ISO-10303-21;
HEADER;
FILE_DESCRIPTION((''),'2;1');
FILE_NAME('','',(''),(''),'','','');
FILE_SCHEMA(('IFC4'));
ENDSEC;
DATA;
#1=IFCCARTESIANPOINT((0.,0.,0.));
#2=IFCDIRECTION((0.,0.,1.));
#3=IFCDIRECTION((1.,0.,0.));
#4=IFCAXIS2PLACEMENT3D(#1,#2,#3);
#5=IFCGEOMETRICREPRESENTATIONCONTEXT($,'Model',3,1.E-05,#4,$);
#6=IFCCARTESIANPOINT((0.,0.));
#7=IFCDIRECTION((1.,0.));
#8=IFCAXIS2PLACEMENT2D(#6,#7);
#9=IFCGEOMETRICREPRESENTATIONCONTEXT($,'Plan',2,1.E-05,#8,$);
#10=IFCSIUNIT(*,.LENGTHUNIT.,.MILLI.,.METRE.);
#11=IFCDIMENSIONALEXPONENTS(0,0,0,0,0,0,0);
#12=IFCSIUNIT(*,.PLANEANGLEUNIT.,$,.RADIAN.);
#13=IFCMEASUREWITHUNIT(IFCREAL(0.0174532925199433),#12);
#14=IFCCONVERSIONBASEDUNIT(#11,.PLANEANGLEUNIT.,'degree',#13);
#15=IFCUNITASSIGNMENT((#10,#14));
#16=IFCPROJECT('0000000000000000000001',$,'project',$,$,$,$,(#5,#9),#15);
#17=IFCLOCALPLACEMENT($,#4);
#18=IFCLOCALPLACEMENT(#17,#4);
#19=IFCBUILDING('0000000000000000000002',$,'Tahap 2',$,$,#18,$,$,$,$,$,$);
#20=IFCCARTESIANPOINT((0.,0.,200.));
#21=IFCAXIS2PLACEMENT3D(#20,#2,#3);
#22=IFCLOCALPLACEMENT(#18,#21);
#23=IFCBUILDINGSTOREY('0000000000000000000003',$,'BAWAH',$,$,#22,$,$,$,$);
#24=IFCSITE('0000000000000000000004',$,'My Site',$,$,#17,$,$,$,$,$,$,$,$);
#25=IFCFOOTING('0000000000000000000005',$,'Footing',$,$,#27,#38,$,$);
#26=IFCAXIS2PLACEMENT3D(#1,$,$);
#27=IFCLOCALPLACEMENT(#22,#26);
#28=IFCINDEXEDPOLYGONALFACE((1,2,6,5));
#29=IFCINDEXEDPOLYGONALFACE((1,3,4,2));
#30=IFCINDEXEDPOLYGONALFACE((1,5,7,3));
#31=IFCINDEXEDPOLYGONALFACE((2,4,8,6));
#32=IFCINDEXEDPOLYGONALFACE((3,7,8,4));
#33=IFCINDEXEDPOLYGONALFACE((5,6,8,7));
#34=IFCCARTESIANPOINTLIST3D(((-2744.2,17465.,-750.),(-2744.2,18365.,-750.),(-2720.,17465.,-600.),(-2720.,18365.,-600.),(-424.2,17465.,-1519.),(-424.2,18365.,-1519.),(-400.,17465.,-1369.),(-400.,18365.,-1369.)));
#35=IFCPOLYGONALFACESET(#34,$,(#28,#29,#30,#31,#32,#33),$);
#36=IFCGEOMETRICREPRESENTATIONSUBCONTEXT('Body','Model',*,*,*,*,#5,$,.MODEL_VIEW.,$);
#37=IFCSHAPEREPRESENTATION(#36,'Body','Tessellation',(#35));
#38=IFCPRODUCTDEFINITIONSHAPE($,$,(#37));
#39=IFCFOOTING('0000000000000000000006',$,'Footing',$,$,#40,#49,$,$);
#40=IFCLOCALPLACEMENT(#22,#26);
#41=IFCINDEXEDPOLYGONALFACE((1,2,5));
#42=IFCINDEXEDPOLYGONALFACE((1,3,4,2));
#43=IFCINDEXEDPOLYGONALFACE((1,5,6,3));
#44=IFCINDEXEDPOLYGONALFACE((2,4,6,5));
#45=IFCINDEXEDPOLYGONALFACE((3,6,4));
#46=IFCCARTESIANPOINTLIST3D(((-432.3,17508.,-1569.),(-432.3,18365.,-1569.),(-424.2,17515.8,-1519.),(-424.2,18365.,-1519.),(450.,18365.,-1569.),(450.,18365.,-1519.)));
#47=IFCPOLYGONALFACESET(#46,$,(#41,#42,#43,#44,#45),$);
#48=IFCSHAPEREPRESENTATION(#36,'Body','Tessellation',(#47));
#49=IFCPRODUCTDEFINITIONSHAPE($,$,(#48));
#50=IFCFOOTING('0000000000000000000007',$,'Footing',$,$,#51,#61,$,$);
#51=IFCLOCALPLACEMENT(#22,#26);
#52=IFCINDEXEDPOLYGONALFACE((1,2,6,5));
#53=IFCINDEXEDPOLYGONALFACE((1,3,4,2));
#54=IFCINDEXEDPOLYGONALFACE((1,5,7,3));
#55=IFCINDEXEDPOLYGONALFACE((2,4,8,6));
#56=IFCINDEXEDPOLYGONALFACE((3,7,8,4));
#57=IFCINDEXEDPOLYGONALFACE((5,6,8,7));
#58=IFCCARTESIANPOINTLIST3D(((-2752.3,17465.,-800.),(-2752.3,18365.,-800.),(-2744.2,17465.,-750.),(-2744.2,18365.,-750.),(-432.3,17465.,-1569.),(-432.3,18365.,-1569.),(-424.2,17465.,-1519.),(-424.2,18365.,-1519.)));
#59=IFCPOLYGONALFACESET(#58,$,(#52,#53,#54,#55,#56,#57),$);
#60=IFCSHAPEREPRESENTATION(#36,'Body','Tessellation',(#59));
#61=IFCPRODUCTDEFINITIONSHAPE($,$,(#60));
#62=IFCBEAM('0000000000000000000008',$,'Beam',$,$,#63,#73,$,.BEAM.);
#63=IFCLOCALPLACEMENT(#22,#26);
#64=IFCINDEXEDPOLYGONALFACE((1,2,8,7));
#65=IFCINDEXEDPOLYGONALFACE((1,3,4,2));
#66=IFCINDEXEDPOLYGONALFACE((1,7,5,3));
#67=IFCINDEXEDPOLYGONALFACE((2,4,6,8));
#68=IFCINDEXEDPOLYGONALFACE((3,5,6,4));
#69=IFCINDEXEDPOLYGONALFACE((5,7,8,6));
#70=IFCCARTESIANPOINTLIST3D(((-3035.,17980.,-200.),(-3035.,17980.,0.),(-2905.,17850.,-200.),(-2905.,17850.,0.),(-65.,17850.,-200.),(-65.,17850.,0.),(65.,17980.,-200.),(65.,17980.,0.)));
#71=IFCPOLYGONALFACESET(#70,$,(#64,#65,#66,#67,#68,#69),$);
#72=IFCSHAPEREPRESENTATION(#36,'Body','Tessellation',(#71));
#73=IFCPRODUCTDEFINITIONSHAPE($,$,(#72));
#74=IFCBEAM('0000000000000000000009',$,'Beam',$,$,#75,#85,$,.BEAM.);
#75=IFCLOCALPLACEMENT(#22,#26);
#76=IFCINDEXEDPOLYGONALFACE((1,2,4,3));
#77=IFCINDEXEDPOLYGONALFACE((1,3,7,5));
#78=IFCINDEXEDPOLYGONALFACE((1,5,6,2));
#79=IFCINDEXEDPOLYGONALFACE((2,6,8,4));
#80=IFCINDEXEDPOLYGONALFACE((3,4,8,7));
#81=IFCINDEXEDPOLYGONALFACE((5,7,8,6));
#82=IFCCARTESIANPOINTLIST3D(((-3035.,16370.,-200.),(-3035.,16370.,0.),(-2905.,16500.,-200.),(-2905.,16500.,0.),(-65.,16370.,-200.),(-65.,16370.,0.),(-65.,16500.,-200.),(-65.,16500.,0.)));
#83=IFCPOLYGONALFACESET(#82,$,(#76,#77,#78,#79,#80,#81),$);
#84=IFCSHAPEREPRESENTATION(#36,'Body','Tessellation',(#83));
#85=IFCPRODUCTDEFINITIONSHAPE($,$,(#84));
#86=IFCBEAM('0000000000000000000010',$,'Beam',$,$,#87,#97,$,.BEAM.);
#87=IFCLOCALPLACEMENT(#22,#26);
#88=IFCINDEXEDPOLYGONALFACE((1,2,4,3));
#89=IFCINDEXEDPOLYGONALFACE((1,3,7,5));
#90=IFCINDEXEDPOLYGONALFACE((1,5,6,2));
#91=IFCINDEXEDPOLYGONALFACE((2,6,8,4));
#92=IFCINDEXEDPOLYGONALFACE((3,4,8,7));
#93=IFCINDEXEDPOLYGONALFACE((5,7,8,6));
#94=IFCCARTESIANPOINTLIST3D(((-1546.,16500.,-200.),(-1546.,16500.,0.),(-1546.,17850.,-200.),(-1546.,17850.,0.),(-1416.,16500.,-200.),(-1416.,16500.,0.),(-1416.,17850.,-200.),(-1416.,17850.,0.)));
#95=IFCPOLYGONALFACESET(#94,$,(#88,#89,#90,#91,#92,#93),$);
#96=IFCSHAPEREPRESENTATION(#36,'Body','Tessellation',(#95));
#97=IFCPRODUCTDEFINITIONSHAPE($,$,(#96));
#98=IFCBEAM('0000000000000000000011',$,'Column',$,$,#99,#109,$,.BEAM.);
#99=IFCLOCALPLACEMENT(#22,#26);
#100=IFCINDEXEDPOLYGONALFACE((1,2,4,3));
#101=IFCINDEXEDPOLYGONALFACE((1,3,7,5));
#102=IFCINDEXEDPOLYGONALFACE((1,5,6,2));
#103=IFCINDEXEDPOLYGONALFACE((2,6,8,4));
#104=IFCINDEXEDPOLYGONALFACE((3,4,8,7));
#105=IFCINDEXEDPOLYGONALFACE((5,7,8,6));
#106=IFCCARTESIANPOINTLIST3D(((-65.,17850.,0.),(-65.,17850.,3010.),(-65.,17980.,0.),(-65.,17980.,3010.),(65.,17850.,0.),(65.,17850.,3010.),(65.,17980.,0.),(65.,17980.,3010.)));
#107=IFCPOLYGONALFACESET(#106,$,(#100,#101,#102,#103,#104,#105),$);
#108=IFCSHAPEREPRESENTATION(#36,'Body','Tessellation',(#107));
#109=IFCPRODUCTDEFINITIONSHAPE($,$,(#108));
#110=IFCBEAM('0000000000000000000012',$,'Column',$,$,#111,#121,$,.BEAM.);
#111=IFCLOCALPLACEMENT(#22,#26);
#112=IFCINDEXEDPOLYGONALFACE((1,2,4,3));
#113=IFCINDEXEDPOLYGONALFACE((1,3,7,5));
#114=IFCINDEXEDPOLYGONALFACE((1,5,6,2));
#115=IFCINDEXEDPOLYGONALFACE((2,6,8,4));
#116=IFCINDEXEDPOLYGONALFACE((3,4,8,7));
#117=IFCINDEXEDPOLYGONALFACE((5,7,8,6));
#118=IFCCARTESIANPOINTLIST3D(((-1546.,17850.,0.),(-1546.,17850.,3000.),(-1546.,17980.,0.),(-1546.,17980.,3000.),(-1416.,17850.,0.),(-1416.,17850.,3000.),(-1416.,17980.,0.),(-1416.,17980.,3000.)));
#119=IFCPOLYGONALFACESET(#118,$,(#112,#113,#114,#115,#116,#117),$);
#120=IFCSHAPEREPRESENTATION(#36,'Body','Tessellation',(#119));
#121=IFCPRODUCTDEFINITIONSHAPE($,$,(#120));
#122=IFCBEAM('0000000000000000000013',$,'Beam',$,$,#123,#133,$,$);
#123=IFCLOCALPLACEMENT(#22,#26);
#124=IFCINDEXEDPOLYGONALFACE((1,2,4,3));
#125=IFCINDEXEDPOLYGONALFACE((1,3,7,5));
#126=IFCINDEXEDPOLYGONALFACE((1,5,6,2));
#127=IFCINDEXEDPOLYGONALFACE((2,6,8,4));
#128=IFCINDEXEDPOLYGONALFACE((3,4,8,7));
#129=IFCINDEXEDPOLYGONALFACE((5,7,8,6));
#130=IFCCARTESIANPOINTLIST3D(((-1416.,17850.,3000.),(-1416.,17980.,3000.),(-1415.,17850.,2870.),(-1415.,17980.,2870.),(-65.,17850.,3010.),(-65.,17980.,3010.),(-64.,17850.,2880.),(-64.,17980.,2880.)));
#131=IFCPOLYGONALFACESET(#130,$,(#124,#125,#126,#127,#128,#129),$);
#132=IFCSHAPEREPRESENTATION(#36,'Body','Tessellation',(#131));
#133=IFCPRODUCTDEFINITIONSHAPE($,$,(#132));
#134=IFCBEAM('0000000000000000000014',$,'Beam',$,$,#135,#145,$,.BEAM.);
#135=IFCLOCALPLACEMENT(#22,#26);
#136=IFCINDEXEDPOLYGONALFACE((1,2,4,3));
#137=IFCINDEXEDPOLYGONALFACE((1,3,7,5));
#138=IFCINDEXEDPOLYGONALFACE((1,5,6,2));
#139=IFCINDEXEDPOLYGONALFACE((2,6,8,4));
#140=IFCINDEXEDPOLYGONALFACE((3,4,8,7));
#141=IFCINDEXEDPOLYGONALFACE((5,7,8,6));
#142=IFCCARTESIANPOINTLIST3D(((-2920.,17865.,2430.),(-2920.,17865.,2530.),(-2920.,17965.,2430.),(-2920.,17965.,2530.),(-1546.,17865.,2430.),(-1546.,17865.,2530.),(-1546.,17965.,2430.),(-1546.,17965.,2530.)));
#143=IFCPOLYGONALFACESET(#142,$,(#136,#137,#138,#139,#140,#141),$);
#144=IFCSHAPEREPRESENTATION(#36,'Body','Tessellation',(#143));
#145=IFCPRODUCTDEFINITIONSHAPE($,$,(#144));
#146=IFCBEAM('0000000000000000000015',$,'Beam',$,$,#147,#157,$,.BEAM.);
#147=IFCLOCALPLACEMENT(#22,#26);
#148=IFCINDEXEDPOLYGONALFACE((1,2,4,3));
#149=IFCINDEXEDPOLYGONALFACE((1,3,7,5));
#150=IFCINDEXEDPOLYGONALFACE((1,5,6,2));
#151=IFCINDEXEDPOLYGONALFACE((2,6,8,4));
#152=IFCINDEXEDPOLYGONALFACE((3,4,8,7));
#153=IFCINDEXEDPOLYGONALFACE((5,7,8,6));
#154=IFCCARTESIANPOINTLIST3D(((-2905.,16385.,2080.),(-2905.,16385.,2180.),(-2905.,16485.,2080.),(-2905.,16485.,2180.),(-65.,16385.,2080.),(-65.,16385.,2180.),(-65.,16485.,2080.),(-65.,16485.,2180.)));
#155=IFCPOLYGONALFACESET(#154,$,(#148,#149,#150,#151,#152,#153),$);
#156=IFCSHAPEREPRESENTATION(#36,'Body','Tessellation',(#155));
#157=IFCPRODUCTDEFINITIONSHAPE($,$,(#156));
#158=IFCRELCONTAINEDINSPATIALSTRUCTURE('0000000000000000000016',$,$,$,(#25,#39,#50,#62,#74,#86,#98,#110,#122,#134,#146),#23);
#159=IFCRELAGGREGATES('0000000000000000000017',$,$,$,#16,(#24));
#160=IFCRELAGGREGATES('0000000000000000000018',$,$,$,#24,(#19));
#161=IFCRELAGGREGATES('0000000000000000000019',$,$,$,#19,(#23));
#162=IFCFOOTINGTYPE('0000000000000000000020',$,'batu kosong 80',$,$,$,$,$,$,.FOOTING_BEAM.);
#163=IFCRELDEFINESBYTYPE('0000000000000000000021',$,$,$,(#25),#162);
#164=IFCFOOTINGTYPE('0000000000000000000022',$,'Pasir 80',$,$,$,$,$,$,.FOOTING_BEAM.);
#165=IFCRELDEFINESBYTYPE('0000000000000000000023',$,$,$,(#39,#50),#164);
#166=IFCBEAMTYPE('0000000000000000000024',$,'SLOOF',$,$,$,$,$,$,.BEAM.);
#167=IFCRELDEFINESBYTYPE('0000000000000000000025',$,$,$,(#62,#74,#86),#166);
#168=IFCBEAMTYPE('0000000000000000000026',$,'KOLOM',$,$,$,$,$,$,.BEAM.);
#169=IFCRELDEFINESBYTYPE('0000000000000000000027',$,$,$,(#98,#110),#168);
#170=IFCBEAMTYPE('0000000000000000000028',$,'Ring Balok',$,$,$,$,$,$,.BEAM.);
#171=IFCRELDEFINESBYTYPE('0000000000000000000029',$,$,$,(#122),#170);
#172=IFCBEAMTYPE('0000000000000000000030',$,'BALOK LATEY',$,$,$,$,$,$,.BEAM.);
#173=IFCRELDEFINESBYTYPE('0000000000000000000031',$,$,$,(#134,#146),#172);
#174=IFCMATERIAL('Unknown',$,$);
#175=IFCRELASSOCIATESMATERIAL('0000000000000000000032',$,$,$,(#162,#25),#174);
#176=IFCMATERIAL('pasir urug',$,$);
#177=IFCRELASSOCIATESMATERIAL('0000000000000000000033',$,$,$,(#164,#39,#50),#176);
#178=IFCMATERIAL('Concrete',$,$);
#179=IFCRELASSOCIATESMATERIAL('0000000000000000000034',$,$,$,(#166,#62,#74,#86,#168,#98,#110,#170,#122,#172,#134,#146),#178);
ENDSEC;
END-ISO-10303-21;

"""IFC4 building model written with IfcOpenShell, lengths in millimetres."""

from ifc_helpers import new_model, entity, si_unit, converted_unit, frame, origin_with_axes, origin_2d_with_axis, place, context, subcontext, project, spatial, indexed_curve, rectangle, outline, extrude, clip, halfspace, material, material_profile, profile_set, profile_usage, type_object, element, save


model = new_model("IFC4")

# Units and contexts
model_context = context("Model", 3, precision=1e-05, world=origin_with_axes())
plan_context = context("Plan", 2, precision=1e-05, world=origin_2d_with_axis())
body_context_1 = subcontext(model_context, "Body", "Model", "MODEL_VIEW")
ifc_project = project(units=[si_unit("LENGTHUNIT", "METRE", prefix="MILLI"), converted_unit("PLANEANGLEUNIT", "degree", entity("IfcReal", 0.0174532925199433), si_unit("PLANEANGLEUNIT", "RADIAN"), dimensions=[0, 0, 0, 0, 0, 0, 0])], contexts=[model_context, plan_context])

# Site, building, storey
site_placement = place(None, origin_with_axes())
site = spatial("IfcSite", under=ifc_project, at=site_placement, Name="My Site")
building_placement = place(site_placement, origin_with_axes())
building = spatial("IfcBuilding", under=site, at=building_placement, Name="Tahap 2")
storey_placement = place(building_placement, frame((0.0, 0.0, 200.0), z_axis=(0.0, 0.0, 1.0), x_axis=(1.0, 0.0, 0.0)))
storey = spatial("IfcBuildingStorey", under=building, at=storey_placement, Name="BAWAH")

# Footings
ifc_material_1 = material(Name="Unknown")
ifc_material_profile_1 = material_profile(ifc_material_1, rectangle(XDim=900.0, YDim=150.0, kind="CURVE"))
ifc_profile_set_1 = profile_set([ifc_material_profile_1])
footing_type_1 = type_object("IfcFootingType", Name="batu kosong 80", PredefinedType="FOOTING_BEAM", material=ifc_profile_set_1)
ifc_profile_usage_1 = profile_usage(ifc_profile_set_1, cardinal=8)
footing_1_placement = place(storey_placement, frame((906.8, 17915.0, -1802.2), z_axis=(-0.949214, 0.0, 0.314631), x_axis=(0.0, -1.0, 0.0)))
element("IfcFooting", 1, at=footing_1_placement, inside=storey, type_object=footing_type_1, material=ifc_profile_usage_1, Name="Footing", context=body_context_1, shape_type="Clipping", body=[
    clip(clip(extrude(rectangle(XDim=900.0, YDim=150.0, kind="CURVE"), frame((0.0, -75.0, 0.0), z_axis=(0.0, 0.0, 1.0), x_axis=(1.0, 0.0, 0.0)), (0.0, 0.0, 1.0), 4720.9), halfspace(frame((17915.0, 0.0, 3820.9), z_axis=(0.0, -0.159352, 0.987222), x_axis=(-1.0, -0.000001, 0.0)), False)), halfspace(frame((17915.0, -150.0, 1352.5), z_axis=(0.0, 0.15935, -0.987222), x_axis=(1.0, 0.000001, 0.0)), False)),
])
ifc_material_2 = material(Name="pasir urug")
ifc_material_profile_2 = material_profile(ifc_material_2, rectangle(XDim=900.0, YDim=50.0, kind="CURVE"))
ifc_profile_set_2 = profile_set([ifc_material_profile_2])
ifc_profile_usage_2 = profile_usage(ifc_profile_set_2, cardinal=9)
footing_type_2 = type_object("IfcFootingType", Name="Pasir 80", PredefinedType="FOOTING_BEAM", material=ifc_profile_set_2)
footing_2_placement = place(storey_placement, frame((450.0, 18365.0, -1519.0), z_axis=(-1.0, 0.0, -0.000003), x_axis=(0.0, -1.0, 0.0)))
element("IfcFooting", 2, at=footing_2_placement, inside=storey, type_object=footing_type_2, material=ifc_profile_usage_2, Name="Footing", context=body_context_1, shape_type="Clipping", body=[
    clip(clip(extrude(rectangle(XDim=900.0, YDim=50.0, kind="CURVE"), frame((450.0, -25.0, 0.0), z_axis=(0.0, 0.0, 1.0), x_axis=(1.0, 0.0, 0.0)), (0.0, 0.0, 1.0), 1907.3), halfspace(frame((18365.0, -50.0, 882.3), z_axis=(0.0, 0.159346, 0.987223), x_axis=(1.0, 0.0, 0.0)), False)), halfspace(frame((0.0, 1319.0, 0.0), z_axis=(0.717309, -0.000002, -0.696755), x_axis=(-0.000003, -1.0, 0.0)), False)),
])
ifc_profile_usage_3 = profile_usage(ifc_profile_set_2, cardinal=9)
footing_3_placement = place(storey_placement, frame((580.9, 18365.0, -1852.2), z_axis=(-0.949214, 0.0, 0.314631), x_axis=(0.0, -1.0, 0.0)))
element("IfcFooting", 3, at=footing_3_placement, inside=storey, type_object=footing_type_2, material=ifc_profile_usage_3, Name="Footing", context=body_context_1, shape_type="Clipping", body=[
    clip(clip(extrude(rectangle(XDim=900.0, YDim=50.0, kind="CURVE"), frame((450.0, -25.0, 0.0), z_axis=(0.0, 0.0, 1.0), x_axis=(1.0, 0.0, 0.0)), (0.0, 0.0, 1.0), 4403.0), halfspace(frame((18365.0, 0.0, 3503.0), z_axis=(0.0, -0.159366, 0.98722), x_axis=(-1.0, -0.000002, 0.0)), False)), halfspace(frame((18365.0, -50.0, 1050.8), z_axis=(0.0, 0.159359, -0.987221), x_axis=(1.0, 0.0, 0.0)), False)),
])

# Beams
ifc_material_3 = material(Name="Concrete")
ifc_material_profile_3 = material_profile(ifc_material_3, outline(indexed_curve([(-65.0, 100.0), (65.0, 100.0), (65.0, -100.0), (-65.0, -100.0), (-65.0, 100.0)])))
ifc_profile_set_3 = profile_set([ifc_material_profile_3])
ifc_profile_usage_4 = profile_usage(ifc_profile_set_3, cardinal=2)
beam_type_1 = type_object("IfcBeamType", Name="SLOOF", PredefinedType="BEAM", material=ifc_profile_set_3)
beam_1_placement = place(storey_placement, frame((65.0, 17915.0, -200.0), z_axis=(-1.0, 0.0, 0.0), x_axis=(0.0, -1.0, 0.0)))
element("IfcBeam", 4, at=beam_1_placement, inside=storey, type_object=beam_type_1, material=ifc_profile_usage_4, Name="Beam", PredefinedType="BEAM", context=body_context_1, shape_type="Clipping", body=[
    clip(clip(extrude(outline(indexed_curve([(-65.0, 100.0), (65.0, 100.0), (65.0, -100.0), (-65.0, -100.0), (-65.0, 100.0)])), frame((0.0, 100.0, 0.0), z_axis=(0.0, 0.0, 1.0), x_axis=(1.0, 0.0, 0.0)), (0.0, 0.0, 1.0), 3100.0), halfspace(frame((-65.0, 0.0, 3100.0), z_axis=(0.707104, 0.0, 0.70711), x_axis=(0.0, -1.0, 0.0)), False)), halfspace(frame((-65.0, 0.0, 0.0), z_axis=(0.707104, 0.0, -0.70711), x_axis=(0.0, -1.0, 0.0)), False)),
])
ifc_profile_usage_5 = profile_usage(ifc_profile_set_3, cardinal=2)
beam_2_placement = place(storey_placement, frame((-65.0, 16435.0, -200.0), z_axis=(-1.0, 0.0, 0.0), x_axis=(0.0, -1.0, 0.0)))
element("IfcBeam", 5, at=beam_2_placement, inside=storey, type_object=beam_type_1, material=ifc_profile_usage_5, Name="Beam", PredefinedType="BEAM", context=body_context_1, shape_type="Clipping", body=[
    clip(extrude(outline(indexed_curve([(-65.0, 100.0), (65.0, 100.0), (65.0, -100.0), (-65.0, -100.0), (-65.0, 100.0)])), frame((0.0, 100.0, 0.0), z_axis=(0.0, 0.0, 1.0), x_axis=(1.0, 0.0, 0.0)), (0.0, 0.0, 1.0), 2970.0), halfspace(frame((65.0, 0.0, 2970.0), z_axis=(-0.707104, 0.0, 0.707109), x_axis=(0.0, 1.0, 0.0)), False)),
])
ifc_profile_usage_6 = profile_usage(ifc_profile_set_3, cardinal=2)
beam_3_placement = place(storey_placement, frame((-1481.0, 17850.0, -200.0), z_axis=(0.0, -1.0, -0.000003), x_axis=(1.0, 0.0, 0.0)))
element("IfcBeam", 6, at=beam_3_placement, inside=storey, type_object=beam_type_1, material=ifc_profile_usage_6, Name="Beam", PredefinedType="BEAM", context=body_context_1, shape_type="SweptSolid", body=[
    extrude(outline(indexed_curve([(-65.0, 100.0), (65.0, 100.0), (65.0, -100.0), (-65.0, -100.0), (-65.0, 100.0)])), frame((0.0, 100.0, 0.0), z_axis=(0.0, 0.0, 1.0), x_axis=(1.0, 0.0, 0.0)), (0.0, 0.0, 1.0), 1350.0),
])
ifc_material_profile_4 = material_profile(ifc_material_3, rectangle(XDim=130.0, YDim=130.0, kind="CURVE"))
ifc_profile_set_4 = profile_set([ifc_material_profile_4])
ifc_profile_usage_7 = profile_usage(ifc_profile_set_4, cardinal=5)
beam_type_2 = type_object("IfcBeamType", Name="KOLOM", PredefinedType="BEAM", material=ifc_profile_set_4)
beam_4_placement = place(storey_placement, frame((0.0, 17915.0, 0.0), z_axis=(0.0, 0.0, 1.0), x_axis=(1.0, 0.0, 0.0)))
element("IfcBeam", 7, at=beam_4_placement, inside=storey, type_object=beam_type_2, material=ifc_profile_usage_7, Name="Column", PredefinedType="BEAM", context=body_context_1, shape_type="SweptSolid", body=[
    extrude(rectangle(XDim=130.0, YDim=130.0, kind="CURVE"), origin_with_axes(), (0.0, 0.0, 1.0), 3010.0),
])
ifc_profile_usage_8 = profile_usage(ifc_profile_set_4, cardinal=2)
beam_5_placement = place(storey_placement, frame((-1481.0, 17850.0, 0.0), z_axis=(0.0, 0.0, 1.0), x_axis=(1.0, 0.0, 0.0)))
element("IfcBeam", 8, at=beam_5_placement, inside=storey, type_object=beam_type_2, material=ifc_profile_usage_8, Name="Column", PredefinedType="BEAM", context=body_context_1, shape_type="SweptSolid", body=[
    extrude(rectangle(XDim=130.0, YDim=130.0, kind="CURVE"), frame((0.0, 65.0, 0.0), z_axis=(0.0, 0.0, 1.0), x_axis=(1.0, 0.0, 0.0)), (0.0, 0.0, 1.0), 3000.0),
])
ifc_material_profile_5 = material_profile(ifc_material_3, rectangle(XDim=130.0, YDim=130.0))
ifc_profile_set_5 = profile_set([ifc_material_profile_5])
ifc_profile_usage_9 = profile_usage(ifc_profile_set_5, cardinal=9)
beam_type_3 = type_object("IfcBeamType", Name="Ring Balok", PredefinedType="BEAM", material=ifc_profile_set_5)
beam_6_placement = place(storey_placement, frame((-65.0, 17980.0, 3010.0), z_axis=(-0.999973, 0.000014, -0.007411), x_axis=(-0.000014, -1.0, 0.0)))
element("IfcBeam", 9, at=beam_6_placement, inside=storey, type_object=beam_type_3, material=ifc_profile_usage_9, Name="Beam", context=body_context_1, shape_type="SweptSolid", body=[
    extrude(rectangle(XDim=130.0, YDim=130.0), frame((65.0, -65.0, 0.0), z_axis=(0.0, 0.0, 1.0), x_axis=(1.0, 0.0, 0.0)), (0.0, 0.0, 1.0), 1351.0),
])

# Beams
ifc_material_profile_6 = material_profile(ifc_material_3, rectangle(XDim=100.0, YDim=100.0))
ifc_profile_set_6 = profile_set([ifc_material_profile_6])
ifc_profile_usage_10 = profile_usage(ifc_profile_set_6, cardinal=2)
beam_type_4 = type_object("IfcBeamType", Name="BALOK LATEY", PredefinedType="BEAM", material=ifc_profile_set_6)
beam_7_placement = place(storey_placement, frame((-1546.0, 17915.0, 2430.0), z_axis=(-1.0, 0.0, 0.0), x_axis=(0.0, -1.0, 0.0)))
element("IfcBeam", 10, at=beam_7_placement, inside=storey, type_object=beam_type_4, material=ifc_profile_usage_10, Name="Beam", PredefinedType="BEAM", context=body_context_1, shape_type="SweptSolid", body=[
    extrude(rectangle(XDim=100.0, YDim=100.0), frame((0.0, 50.0, 0.0), z_axis=(0.0, 0.0, 1.0), x_axis=(1.0, 0.0, 0.0)), (0.0, 0.0, 1.0), 1374.0),
])
ifc_profile_usage_11 = profile_usage(ifc_profile_set_6, cardinal=2)
beam_8_placement = place(storey_placement, frame((-65.0, 16435.0, 2080.0), z_axis=(-1.0, 0.0, 0.0), x_axis=(0.0, -1.0, 0.0)))
element("IfcBeam", 11, at=beam_8_placement, inside=storey, type_object=beam_type_4, material=ifc_profile_usage_11, Name="Beam", PredefinedType="BEAM", context=body_context_1, shape_type="SweptSolid", body=[
    extrude(rectangle(XDim=100.0, YDim=100.0), frame((0.0, 50.0, 0.0), z_axis=(0.0, 0.0, 1.0), x_axis=(1.0, 0.0, 0.0)), (0.0, 0.0, 1.0), 2840.0),
])

save(model, "model.ifc")
